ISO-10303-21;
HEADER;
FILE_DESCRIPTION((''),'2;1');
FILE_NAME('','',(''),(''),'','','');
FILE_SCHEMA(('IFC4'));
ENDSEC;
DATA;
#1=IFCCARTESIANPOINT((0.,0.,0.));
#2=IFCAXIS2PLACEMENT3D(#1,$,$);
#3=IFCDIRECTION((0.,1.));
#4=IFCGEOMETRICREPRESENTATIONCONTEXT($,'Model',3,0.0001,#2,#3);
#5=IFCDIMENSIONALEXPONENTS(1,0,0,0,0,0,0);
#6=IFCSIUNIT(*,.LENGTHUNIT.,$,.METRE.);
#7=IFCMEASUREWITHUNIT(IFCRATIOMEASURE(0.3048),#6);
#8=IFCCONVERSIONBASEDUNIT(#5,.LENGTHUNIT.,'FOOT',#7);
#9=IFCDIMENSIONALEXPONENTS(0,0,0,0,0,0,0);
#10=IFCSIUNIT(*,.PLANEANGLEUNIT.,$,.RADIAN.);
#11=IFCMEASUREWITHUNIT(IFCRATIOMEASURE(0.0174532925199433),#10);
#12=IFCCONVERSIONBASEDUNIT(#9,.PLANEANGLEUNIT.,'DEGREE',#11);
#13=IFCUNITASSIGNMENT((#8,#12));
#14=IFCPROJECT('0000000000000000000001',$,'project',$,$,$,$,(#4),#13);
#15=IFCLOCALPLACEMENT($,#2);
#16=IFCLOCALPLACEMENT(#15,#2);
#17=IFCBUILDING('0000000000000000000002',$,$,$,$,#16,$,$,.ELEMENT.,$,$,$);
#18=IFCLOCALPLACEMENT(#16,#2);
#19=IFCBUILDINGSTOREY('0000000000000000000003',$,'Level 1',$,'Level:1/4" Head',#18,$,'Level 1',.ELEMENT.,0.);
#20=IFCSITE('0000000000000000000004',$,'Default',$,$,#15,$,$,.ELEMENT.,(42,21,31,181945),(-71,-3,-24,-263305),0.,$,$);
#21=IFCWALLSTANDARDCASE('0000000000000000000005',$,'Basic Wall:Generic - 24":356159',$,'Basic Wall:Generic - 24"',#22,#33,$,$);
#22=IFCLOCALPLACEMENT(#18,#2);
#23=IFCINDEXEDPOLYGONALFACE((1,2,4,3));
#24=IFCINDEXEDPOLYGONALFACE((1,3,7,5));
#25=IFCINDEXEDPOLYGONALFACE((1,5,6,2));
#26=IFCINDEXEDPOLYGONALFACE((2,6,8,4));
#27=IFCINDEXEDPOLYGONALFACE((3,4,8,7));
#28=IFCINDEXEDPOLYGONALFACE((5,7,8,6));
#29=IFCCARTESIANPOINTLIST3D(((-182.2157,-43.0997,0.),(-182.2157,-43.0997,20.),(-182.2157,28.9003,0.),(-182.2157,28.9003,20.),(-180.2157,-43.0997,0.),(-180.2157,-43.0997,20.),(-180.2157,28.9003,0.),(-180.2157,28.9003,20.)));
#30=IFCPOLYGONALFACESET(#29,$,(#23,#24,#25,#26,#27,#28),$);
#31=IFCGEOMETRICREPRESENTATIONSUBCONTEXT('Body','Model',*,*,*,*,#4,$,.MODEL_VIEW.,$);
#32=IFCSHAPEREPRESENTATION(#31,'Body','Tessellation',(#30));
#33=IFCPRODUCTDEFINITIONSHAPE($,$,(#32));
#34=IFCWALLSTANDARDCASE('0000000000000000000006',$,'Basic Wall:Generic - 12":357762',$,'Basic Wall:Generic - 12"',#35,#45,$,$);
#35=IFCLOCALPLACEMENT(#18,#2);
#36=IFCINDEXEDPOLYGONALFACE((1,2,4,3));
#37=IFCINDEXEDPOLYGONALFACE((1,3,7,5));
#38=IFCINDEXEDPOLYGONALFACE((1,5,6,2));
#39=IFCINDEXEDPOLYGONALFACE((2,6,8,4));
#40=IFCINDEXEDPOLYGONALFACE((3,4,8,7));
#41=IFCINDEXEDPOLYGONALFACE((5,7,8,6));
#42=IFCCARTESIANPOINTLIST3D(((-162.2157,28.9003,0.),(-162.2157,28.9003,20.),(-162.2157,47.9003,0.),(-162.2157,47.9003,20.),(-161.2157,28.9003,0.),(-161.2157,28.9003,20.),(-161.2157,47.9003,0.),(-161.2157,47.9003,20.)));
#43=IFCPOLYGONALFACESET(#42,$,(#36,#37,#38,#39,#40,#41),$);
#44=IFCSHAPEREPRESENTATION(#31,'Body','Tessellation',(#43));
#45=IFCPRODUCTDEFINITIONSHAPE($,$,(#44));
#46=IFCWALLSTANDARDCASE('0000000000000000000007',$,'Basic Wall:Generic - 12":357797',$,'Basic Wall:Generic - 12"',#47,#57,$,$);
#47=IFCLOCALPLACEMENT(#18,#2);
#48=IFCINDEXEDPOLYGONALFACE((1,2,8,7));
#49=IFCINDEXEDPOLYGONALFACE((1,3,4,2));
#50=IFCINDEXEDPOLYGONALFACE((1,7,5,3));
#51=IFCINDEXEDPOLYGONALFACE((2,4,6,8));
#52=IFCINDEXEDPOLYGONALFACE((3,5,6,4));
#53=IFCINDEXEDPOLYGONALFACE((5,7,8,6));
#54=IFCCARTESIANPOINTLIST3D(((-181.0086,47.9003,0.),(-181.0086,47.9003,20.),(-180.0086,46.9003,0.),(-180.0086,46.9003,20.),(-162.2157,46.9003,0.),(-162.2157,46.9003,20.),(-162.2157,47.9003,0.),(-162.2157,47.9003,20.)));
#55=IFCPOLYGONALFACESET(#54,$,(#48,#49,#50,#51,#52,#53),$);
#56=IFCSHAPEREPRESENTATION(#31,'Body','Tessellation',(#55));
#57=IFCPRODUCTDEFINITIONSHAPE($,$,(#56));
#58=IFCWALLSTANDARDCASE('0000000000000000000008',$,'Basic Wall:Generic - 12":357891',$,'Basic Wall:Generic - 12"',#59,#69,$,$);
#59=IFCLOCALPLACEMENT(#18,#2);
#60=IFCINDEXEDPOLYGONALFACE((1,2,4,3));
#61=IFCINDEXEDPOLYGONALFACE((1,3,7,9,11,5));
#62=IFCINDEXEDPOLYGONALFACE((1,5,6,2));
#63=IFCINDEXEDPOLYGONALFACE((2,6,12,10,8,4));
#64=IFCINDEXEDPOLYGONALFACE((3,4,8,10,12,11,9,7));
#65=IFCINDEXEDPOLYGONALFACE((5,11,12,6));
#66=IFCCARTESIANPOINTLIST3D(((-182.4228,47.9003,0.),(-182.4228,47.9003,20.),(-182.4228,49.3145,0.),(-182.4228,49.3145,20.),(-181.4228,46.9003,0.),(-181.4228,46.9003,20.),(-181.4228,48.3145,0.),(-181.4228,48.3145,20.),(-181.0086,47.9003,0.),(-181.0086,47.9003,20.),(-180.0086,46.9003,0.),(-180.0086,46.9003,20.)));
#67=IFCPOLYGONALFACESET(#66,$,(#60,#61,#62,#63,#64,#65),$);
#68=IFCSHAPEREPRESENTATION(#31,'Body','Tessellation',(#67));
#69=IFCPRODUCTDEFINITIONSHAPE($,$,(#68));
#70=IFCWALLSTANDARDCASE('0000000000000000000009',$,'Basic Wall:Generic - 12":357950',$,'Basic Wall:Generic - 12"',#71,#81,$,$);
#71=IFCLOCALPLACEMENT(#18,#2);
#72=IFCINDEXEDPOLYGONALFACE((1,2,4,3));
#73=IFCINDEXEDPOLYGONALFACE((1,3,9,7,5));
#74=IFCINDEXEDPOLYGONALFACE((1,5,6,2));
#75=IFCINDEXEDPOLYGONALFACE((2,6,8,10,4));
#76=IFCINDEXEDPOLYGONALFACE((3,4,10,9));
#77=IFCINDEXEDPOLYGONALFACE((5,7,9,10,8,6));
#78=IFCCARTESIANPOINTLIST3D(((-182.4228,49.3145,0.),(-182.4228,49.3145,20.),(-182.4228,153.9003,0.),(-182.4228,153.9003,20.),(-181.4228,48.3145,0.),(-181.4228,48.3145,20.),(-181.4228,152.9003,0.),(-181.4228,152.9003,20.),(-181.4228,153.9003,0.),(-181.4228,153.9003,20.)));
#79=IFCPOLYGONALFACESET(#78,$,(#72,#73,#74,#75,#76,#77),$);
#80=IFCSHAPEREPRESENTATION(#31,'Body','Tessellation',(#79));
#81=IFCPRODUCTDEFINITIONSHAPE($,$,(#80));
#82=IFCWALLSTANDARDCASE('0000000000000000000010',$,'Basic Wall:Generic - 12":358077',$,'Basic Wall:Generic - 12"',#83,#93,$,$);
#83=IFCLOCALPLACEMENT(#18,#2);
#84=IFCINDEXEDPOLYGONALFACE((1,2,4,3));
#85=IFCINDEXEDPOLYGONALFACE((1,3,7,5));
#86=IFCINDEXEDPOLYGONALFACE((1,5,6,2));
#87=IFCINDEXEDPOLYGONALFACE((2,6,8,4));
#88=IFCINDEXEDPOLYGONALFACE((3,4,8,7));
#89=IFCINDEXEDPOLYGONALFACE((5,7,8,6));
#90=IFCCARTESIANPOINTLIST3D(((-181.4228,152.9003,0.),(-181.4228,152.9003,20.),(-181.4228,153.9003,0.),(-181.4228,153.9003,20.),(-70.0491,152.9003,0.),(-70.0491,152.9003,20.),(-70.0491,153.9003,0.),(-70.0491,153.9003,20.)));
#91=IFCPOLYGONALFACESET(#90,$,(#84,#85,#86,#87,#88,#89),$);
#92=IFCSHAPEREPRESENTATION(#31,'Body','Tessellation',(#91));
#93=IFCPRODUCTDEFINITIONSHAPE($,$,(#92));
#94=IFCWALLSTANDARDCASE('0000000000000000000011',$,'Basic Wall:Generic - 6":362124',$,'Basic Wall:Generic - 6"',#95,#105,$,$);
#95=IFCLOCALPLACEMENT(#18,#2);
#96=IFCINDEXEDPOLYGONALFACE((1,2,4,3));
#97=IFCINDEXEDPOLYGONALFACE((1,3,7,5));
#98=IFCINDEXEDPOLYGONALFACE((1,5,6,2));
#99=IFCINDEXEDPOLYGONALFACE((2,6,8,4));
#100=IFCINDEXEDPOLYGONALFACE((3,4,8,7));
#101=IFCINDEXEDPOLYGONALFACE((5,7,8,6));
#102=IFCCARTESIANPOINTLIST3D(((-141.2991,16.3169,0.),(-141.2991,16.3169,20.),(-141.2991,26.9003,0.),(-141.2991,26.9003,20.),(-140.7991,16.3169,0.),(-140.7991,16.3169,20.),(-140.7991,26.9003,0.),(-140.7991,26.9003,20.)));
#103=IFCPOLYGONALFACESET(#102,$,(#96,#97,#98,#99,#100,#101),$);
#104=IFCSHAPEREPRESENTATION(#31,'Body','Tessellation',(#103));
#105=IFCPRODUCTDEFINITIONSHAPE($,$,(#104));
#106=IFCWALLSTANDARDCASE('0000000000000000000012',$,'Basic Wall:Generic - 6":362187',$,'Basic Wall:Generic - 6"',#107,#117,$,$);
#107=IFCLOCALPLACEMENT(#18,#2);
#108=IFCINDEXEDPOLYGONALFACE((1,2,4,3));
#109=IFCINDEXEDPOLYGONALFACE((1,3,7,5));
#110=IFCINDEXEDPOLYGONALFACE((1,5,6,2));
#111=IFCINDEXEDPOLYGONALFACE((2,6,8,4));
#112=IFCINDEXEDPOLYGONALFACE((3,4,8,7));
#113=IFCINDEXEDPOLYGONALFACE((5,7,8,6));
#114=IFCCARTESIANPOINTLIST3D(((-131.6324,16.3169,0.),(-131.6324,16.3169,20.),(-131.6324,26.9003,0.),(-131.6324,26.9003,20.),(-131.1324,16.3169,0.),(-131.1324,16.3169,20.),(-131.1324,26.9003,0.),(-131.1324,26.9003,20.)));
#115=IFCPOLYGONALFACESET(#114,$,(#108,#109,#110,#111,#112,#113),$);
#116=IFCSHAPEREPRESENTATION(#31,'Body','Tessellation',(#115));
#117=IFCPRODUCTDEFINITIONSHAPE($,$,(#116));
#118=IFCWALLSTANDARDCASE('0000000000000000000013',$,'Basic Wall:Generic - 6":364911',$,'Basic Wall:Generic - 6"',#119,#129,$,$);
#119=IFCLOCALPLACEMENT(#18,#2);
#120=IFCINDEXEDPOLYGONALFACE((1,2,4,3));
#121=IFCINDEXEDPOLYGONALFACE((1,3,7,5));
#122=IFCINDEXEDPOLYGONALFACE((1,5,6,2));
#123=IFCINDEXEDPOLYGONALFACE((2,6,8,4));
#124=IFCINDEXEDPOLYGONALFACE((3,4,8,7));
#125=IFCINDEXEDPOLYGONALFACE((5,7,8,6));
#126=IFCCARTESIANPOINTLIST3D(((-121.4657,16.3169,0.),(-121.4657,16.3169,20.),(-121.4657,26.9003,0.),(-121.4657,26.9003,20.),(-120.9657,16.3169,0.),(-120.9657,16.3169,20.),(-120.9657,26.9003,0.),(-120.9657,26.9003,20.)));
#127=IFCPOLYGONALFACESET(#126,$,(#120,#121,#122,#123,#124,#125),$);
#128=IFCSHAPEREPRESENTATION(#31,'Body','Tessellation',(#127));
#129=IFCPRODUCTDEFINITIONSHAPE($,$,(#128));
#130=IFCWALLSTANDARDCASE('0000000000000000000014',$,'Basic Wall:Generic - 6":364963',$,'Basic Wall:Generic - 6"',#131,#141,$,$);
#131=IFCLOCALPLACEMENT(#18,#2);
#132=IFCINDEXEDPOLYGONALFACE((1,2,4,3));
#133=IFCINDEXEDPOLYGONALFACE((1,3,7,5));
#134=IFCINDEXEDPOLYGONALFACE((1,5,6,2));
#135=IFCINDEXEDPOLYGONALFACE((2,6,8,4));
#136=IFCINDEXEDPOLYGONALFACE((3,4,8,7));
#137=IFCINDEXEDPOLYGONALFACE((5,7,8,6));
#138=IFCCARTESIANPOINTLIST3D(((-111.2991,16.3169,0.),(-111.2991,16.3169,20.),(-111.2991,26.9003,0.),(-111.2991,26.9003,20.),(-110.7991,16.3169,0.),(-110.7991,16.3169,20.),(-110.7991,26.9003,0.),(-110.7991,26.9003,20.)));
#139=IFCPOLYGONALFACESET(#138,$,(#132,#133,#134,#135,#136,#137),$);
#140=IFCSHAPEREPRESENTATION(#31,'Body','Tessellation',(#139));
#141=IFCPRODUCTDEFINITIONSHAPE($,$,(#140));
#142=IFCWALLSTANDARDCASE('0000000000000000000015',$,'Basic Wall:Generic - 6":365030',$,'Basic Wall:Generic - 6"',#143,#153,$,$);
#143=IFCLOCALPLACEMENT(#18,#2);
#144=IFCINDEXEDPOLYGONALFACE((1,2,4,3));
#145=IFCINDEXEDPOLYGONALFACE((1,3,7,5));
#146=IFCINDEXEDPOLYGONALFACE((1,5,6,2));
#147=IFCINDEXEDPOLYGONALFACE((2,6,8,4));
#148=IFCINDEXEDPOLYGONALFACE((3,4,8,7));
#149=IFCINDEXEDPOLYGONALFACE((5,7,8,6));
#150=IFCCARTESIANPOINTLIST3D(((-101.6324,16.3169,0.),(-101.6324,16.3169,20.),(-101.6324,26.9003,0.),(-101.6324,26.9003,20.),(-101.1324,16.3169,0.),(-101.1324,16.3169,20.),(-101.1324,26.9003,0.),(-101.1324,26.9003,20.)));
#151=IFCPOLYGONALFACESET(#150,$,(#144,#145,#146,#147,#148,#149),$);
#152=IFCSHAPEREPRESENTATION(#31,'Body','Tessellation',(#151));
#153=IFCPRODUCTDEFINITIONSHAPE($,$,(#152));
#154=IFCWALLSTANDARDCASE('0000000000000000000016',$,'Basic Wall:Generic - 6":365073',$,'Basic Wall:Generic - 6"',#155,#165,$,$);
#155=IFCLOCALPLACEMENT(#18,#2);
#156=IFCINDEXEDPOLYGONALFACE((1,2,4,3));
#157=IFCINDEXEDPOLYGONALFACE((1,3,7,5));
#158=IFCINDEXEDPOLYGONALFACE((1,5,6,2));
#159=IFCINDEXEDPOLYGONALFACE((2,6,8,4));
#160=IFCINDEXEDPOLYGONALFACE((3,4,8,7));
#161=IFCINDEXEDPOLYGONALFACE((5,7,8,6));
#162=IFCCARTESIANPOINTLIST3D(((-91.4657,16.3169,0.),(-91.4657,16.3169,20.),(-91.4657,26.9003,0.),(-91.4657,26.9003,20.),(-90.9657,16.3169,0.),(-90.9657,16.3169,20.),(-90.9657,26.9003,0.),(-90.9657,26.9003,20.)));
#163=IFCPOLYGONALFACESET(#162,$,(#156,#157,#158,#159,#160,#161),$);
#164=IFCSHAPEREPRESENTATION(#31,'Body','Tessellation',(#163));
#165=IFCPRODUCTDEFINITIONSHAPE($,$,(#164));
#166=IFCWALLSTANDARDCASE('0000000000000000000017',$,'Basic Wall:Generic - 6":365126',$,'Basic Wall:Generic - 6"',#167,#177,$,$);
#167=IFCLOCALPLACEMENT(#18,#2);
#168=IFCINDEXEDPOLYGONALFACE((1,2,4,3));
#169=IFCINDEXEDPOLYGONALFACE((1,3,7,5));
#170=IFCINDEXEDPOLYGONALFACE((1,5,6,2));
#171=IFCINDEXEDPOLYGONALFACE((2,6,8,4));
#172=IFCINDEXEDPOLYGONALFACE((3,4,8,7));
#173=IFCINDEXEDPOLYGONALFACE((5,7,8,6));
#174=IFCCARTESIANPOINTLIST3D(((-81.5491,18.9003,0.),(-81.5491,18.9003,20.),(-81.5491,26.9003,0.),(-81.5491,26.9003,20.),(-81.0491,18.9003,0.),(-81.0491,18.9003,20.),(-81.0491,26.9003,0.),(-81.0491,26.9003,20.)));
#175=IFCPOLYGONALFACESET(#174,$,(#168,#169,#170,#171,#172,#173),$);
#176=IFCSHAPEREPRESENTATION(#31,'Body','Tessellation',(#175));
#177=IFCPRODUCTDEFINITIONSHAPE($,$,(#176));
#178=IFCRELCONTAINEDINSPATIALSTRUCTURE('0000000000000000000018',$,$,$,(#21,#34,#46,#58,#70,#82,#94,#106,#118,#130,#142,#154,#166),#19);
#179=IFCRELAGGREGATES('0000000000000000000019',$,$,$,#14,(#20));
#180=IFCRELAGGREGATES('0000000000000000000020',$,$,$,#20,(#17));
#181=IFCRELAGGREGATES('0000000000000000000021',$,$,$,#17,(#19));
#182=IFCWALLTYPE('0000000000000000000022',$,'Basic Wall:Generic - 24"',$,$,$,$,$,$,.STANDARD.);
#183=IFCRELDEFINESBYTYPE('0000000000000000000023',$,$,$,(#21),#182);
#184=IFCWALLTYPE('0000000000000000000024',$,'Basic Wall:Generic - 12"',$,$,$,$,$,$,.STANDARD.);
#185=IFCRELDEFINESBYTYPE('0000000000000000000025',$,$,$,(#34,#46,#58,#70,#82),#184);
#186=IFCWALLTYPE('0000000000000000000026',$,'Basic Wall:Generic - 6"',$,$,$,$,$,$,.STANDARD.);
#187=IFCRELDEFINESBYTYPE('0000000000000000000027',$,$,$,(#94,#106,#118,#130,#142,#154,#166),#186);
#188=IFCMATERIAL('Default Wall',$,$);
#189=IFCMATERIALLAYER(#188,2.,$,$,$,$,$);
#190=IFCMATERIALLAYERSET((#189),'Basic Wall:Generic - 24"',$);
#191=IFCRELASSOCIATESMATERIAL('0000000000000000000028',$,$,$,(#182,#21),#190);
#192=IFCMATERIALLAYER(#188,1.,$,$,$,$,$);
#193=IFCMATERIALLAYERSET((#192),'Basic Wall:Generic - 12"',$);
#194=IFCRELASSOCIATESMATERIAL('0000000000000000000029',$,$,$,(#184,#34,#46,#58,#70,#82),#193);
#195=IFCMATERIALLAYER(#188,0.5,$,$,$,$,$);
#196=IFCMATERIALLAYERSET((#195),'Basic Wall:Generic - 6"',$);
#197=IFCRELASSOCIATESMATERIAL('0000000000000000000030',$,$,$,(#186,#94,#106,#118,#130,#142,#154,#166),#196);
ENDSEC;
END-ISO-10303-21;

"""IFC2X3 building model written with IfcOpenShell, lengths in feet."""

from ifc_helpers import new_model, entity, si_unit, converted_unit, direction, frame, frame_2d, origin, place, context, subcontext, project, spatial, polyline, rectangle, outline, extrude, material, layer, layer_set, layer_usage, type_object, element, save


model = new_model("IFC2X3")

# Units and contexts
model_context = context("Model", 3, precision=0.0001, world=origin(), true_north=direction((0.0, 1.0)))
body_context = subcontext(model_context, "Body", "Model", "MODEL_VIEW")
ifc_project = project(units=[converted_unit("LENGTHUNIT", "FOOT", entity("IfcRatioMeasure", 0.3048), si_unit("LENGTHUNIT", "METRE"), dimensions=[1, 0, 0, 0, 0, 0, 0]), converted_unit("PLANEANGLEUNIT", "DEGREE", entity("IfcRatioMeasure", 0.0174532925199433), si_unit("PLANEANGLEUNIT", "RADIAN"), dimensions=[0, 0, 0, 0, 0, 0, 0])], contexts=[model_context])

# Site, building, storey
site_placement = place(None, origin())
site = spatial("IfcSite", under=ifc_project, at=site_placement, Name="Default", CompositionType="ELEMENT", RefLatitude=(42, 21, 31, 181945), RefLongitude=(-71, -3, -24, -263305), RefElevation=0.0)
building_placement = place(site_placement, origin())
building = spatial("IfcBuilding", under=site, at=building_placement, CompositionType="ELEMENT")
storey_placement = place(building_placement, origin())
storey = spatial("IfcBuildingStorey", under=building, at=storey_placement, Name="Level 1", ObjectType="Level:1/4\" Head", LongName="Level 1", CompositionType="ELEMENT", Elevation=0.0)

# Walls
ifc_material = material(Name="Default Wall")
ifc_layer_1 = layer(ifc_material, 2.0)
ifc_layer_set_1 = layer_set([ifc_layer_1], Name="Basic Wall:Generic - 24\"")
ifc_layer_usage_1 = layer_usage(ifc_layer_set_1, "AXIS2", "NEGATIVE", 1.0)
wall_type_1 = type_object("IfcWallType", Name="Basic Wall:Generic - 24\"", PredefinedType="STANDARD", material=ifc_layer_set_1)
wall_1_placement = place(storey_placement, frame((-181.2157, 28.9003, 0.0), z_axis=(0.0, 0.0, 1.0), x_axis=(0.0, -1.0, 0.0)))
element("IfcWallStandardCase", 1, at=wall_1_placement, inside=storey, type_object=wall_type_1, material=ifc_layer_usage_1, Name="Basic Wall:Generic - 24\":356159", ObjectType="Basic Wall:Generic - 24\"", context=body_context, shape_type="SweptSolid", body=[
    extrude(rectangle(XDim=72.0, YDim=2.0, at=frame_2d((36.0, 0.0), x_axis=(-1.0, 0.0))), origin(), (0.0, 0.0, 1.0), 20.0),
])
ifc_layer_2 = layer(ifc_material, 1.0)
ifc_layer_set_2 = layer_set([ifc_layer_2], Name="Basic Wall:Generic - 12\"")
ifc_layer_usage_2 = layer_usage(ifc_layer_set_2, "AXIS2", "NEGATIVE", 0.5)
wall_type_2 = type_object("IfcWallType", Name="Basic Wall:Generic - 12\"", PredefinedType="STANDARD", material=ifc_layer_set_2)
wall_2_placement = place(storey_placement, frame((-161.7157, 28.9003, 0.0), z_axis=(0.0, 0.0, 1.0), x_axis=(0.0, 1.0, 0.0)))
element("IfcWallStandardCase", 2, at=wall_2_placement, inside=storey, type_object=wall_type_2, material=ifc_layer_usage_2, Name="Basic Wall:Generic - 12\":357762", ObjectType="Basic Wall:Generic - 12\"", context=body_context, shape_type="SweptSolid", body=[
    extrude(rectangle(XDim=19.0, YDim=1.0, at=frame_2d((9.5, 0.0), x_axis=(-1.0, 0.0))), origin(), (0.0, 0.0, 1.0), 20.0),
])
ifc_layer_usage_3 = layer_usage(ifc_layer_set_2, "AXIS2", "NEGATIVE", 0.5)
wall_3_placement = place(storey_placement, frame((-162.2157, 47.4003, 0.0), z_axis=(0.0, 0.0, 1.0), x_axis=(-1.0, 0.0, 0.0)))
element("IfcWallStandardCase", 3, at=wall_3_placement, inside=storey, type_object=wall_type_2, material=ifc_layer_usage_3, Name="Basic Wall:Generic - 12\":357797", ObjectType="Basic Wall:Generic - 12\"", context=body_context, shape_type="SweptSolid", body=[
    extrude(outline(polyline([(18.7929, -0.5), (17.7929, 0.5), (0.0, 0.5), (0.0, -0.5), (18.7929, -0.5)])), origin(), (0.0, 0.0, 1.0), 20.0),
])
ifc_layer_usage_4 = layer_usage(ifc_layer_set_2, "AXIS2", "NEGATIVE", 0.5)
wall_4_placement = place(storey_placement, frame((-180.3622, 46.5467, 0.0), z_axis=(0.0, 0.0, 1.0), x_axis=(-0.707107, 0.707107, 0.0)))
element("IfcWallStandardCase", 4, at=wall_4_placement, inside=storey, type_object=wall_type_2, material=ifc_layer_usage_4, Name="Basic Wall:Generic - 12\":357891", ObjectType="Basic Wall:Generic - 12\"", context=body_context, shape_type="SweptSolid", body=[
    extrude(outline(polyline([(3.4142, -0.5), (2.4142, 0.5), (1.0, 0.5), (0.0, -0.5), (1.4142, -0.5), (2.0, -0.5), (3.4142, -0.5)])), origin(), (0.0, 0.0, 1.0), 20.0),
])
ifc_layer_usage_5 = layer_usage(ifc_layer_set_2, "AXIS2", "NEGATIVE", 0.5)
wall_5_placement = place(storey_placement, frame((-181.9228, 48.3145, 0.0), z_axis=(0.0, 0.0, 1.0), x_axis=(0.0, 1.0, 0.0)))
element("IfcWallStandardCase", 5, at=wall_5_placement, inside=storey, type_object=wall_type_2, material=ifc_layer_usage_5, Name="Basic Wall:Generic - 12\":357950", ObjectType="Basic Wall:Generic - 12\"", context=body_context, shape_type="SweptSolid", body=[
    extrude(outline(polyline([(105.5858, -0.5), (105.5858, 0.5), (1.0, 0.5), (0.0, -0.5), (104.5858, -0.5), (105.5858, -0.5)])), origin(), (0.0, 0.0, 1.0), 20.0),
])
ifc_layer_usage_6 = layer_usage(ifc_layer_set_2, "AXIS2", "NEGATIVE", 0.5)
wall_6_placement = place(storey_placement, frame((-181.4228, 153.4003, 0.0)))
element("IfcWallStandardCase", 6, at=wall_6_placement, inside=storey, type_object=wall_type_2, material=ifc_layer_usage_6, Name="Basic Wall:Generic - 12\":358077", ObjectType="Basic Wall:Generic - 12\"", context=body_context, shape_type="SweptSolid", body=[
    extrude(rectangle(XDim=111.3738, YDim=1.0, at=frame_2d((55.6869, 0.0), x_axis=(-1.0, 0.0))), origin(), (0.0, 0.0, 1.0), 20.0),
])
ifc_layer_3 = layer(ifc_material, 0.5)
ifc_layer_set_3 = layer_set([ifc_layer_3], Name="Basic Wall:Generic - 6\"")
ifc_layer_usage_7 = layer_usage(ifc_layer_set_3, "AXIS2", "NEGATIVE", 0.25)
wall_type_3 = type_object("IfcWallType", Name="Basic Wall:Generic - 6\"", PredefinedType="STANDARD", material=ifc_layer_set_3)
wall_7_placement = place(storey_placement, frame((-141.0491, 26.9003, 0.0), z_axis=(0.0, 0.0, 1.0), x_axis=(0.0, -1.0, 0.0)))
element("IfcWallStandardCase", 7, at=wall_7_placement, inside=storey, type_object=wall_type_3, material=ifc_layer_usage_7, Name="Basic Wall:Generic - 6\":362124", ObjectType="Basic Wall:Generic - 6\"", context=body_context, shape_type="SweptSolid", body=[
    extrude(rectangle(XDim=10.5833, YDim=0.5, at=frame_2d((5.2917, 0.0), x_axis=(-1.0, 0.0))), origin(), (0.0, 0.0, 1.0), 20.0),
])
ifc_layer_usage_8 = layer_usage(ifc_layer_set_3, "AXIS2", "NEGATIVE", 0.25)
wall_8_placement = place(storey_placement, frame((-131.3824, 26.9003, 0.0), z_axis=(0.0, 0.0, 1.0), x_axis=(0.0, -1.0, 0.0)))
element("IfcWallStandardCase", 8, at=wall_8_placement, inside=storey, type_object=wall_type_3, material=ifc_layer_usage_8, Name="Basic Wall:Generic - 6\":362187", ObjectType="Basic Wall:Generic - 6\"", context=body_context, shape_type="SweptSolid", body=[
    extrude(rectangle(XDim=10.5833, YDim=0.5, at=frame_2d((5.2917, 0.0), x_axis=(-1.0, 0.0))), origin(), (0.0, 0.0, 1.0), 20.0),
])
ifc_layer_usage_9 = layer_usage(ifc_layer_set_3, "AXIS2", "NEGATIVE", 0.25)
wall_9_placement = place(storey_placement, frame((-121.2157, 26.9003, 0.0), z_axis=(0.0, 0.0, 1.0), x_axis=(0.0, -1.0, 0.0)))
element("IfcWallStandardCase", 9, at=wall_9_placement, inside=storey, type_object=wall_type_3, material=ifc_layer_usage_9, Name="Basic Wall:Generic - 6\":364911", ObjectType="Basic Wall:Generic - 6\"", context=body_context, shape_type="SweptSolid", body=[
    extrude(rectangle(XDim=10.5833, YDim=0.5, at=frame_2d((5.2917, 0.0), x_axis=(-1.0, 0.0))), origin(), (0.0, 0.0, 1.0), 20.0),
])
ifc_layer_usage_10 = layer_usage(ifc_layer_set_3, "AXIS2", "NEGATIVE", 0.25)
wall_10_placement = place(storey_placement, frame((-111.0491, 26.9003, 0.0), z_axis=(0.0, 0.0, 1.0), x_axis=(0.0, -1.0, 0.0)))
element("IfcWallStandardCase", 10, at=wall_10_placement, inside=storey, type_object=wall_type_3, material=ifc_layer_usage_10, Name="Basic Wall:Generic - 6\":364963", ObjectType="Basic Wall:Generic - 6\"", context=body_context, shape_type="SweptSolid", body=[
    extrude(rectangle(XDim=10.5833, YDim=0.5, at=frame_2d((5.2917, 0.0), x_axis=(-1.0, 0.0))), origin(), (0.0, 0.0, 1.0), 20.0),
])
ifc_layer_usage_11 = layer_usage(ifc_layer_set_3, "AXIS2", "NEGATIVE", 0.25)
wall_11_placement = place(storey_placement, frame((-101.3824, 26.9003, 0.0), z_axis=(0.0, 0.0, 1.0), x_axis=(0.0, -1.0, 0.0)))
element("IfcWallStandardCase", 11, at=wall_11_placement, inside=storey, type_object=wall_type_3, material=ifc_layer_usage_11, Name="Basic Wall:Generic - 6\":365030", ObjectType="Basic Wall:Generic - 6\"", context=body_context, shape_type="SweptSolid", body=[
    extrude(rectangle(XDim=10.5833, YDim=0.5, at=frame_2d((5.2917, 0.0), x_axis=(-1.0, 0.0))), origin(), (0.0, 0.0, 1.0), 20.0),
])
ifc_layer_usage_12 = layer_usage(ifc_layer_set_3, "AXIS2", "NEGATIVE", 0.25)
wall_12_placement = place(storey_placement, frame((-91.2157, 26.9003, 0.0), z_axis=(0.0, 0.0, 1.0), x_axis=(0.0, -1.0, 0.0)))
element("IfcWallStandardCase", 12, at=wall_12_placement, inside=storey, type_object=wall_type_3, material=ifc_layer_usage_12, Name="Basic Wall:Generic - 6\":365073", ObjectType="Basic Wall:Generic - 6\"", context=body_context, shape_type="SweptSolid", body=[
    extrude(rectangle(XDim=10.5833, YDim=0.5, at=frame_2d((5.2917, 0.0), x_axis=(-1.0, 0.0))), origin(), (0.0, 0.0, 1.0), 20.0),
])
ifc_layer_usage_13 = layer_usage(ifc_layer_set_3, "AXIS2", "NEGATIVE", 0.25)
wall_13_placement = place(storey_placement, frame((-81.2991, 26.9003, 0.0), z_axis=(0.0, 0.0, 1.0), x_axis=(0.0, -1.0, 0.0)))
element("IfcWallStandardCase", 13, at=wall_13_placement, inside=storey, type_object=wall_type_3, material=ifc_layer_usage_13, Name="Basic Wall:Generic - 6\":365126", ObjectType="Basic Wall:Generic - 6\"", context=body_context, shape_type="SweptSolid", body=[
    extrude(rectangle(XDim=8.0, YDim=0.5, at=frame_2d((4.0, 0.0), x_axis=(-1.0, 0.0))), origin(), (0.0, 0.0, 1.0), 20.0),
])

save(model, "model.ifc")
